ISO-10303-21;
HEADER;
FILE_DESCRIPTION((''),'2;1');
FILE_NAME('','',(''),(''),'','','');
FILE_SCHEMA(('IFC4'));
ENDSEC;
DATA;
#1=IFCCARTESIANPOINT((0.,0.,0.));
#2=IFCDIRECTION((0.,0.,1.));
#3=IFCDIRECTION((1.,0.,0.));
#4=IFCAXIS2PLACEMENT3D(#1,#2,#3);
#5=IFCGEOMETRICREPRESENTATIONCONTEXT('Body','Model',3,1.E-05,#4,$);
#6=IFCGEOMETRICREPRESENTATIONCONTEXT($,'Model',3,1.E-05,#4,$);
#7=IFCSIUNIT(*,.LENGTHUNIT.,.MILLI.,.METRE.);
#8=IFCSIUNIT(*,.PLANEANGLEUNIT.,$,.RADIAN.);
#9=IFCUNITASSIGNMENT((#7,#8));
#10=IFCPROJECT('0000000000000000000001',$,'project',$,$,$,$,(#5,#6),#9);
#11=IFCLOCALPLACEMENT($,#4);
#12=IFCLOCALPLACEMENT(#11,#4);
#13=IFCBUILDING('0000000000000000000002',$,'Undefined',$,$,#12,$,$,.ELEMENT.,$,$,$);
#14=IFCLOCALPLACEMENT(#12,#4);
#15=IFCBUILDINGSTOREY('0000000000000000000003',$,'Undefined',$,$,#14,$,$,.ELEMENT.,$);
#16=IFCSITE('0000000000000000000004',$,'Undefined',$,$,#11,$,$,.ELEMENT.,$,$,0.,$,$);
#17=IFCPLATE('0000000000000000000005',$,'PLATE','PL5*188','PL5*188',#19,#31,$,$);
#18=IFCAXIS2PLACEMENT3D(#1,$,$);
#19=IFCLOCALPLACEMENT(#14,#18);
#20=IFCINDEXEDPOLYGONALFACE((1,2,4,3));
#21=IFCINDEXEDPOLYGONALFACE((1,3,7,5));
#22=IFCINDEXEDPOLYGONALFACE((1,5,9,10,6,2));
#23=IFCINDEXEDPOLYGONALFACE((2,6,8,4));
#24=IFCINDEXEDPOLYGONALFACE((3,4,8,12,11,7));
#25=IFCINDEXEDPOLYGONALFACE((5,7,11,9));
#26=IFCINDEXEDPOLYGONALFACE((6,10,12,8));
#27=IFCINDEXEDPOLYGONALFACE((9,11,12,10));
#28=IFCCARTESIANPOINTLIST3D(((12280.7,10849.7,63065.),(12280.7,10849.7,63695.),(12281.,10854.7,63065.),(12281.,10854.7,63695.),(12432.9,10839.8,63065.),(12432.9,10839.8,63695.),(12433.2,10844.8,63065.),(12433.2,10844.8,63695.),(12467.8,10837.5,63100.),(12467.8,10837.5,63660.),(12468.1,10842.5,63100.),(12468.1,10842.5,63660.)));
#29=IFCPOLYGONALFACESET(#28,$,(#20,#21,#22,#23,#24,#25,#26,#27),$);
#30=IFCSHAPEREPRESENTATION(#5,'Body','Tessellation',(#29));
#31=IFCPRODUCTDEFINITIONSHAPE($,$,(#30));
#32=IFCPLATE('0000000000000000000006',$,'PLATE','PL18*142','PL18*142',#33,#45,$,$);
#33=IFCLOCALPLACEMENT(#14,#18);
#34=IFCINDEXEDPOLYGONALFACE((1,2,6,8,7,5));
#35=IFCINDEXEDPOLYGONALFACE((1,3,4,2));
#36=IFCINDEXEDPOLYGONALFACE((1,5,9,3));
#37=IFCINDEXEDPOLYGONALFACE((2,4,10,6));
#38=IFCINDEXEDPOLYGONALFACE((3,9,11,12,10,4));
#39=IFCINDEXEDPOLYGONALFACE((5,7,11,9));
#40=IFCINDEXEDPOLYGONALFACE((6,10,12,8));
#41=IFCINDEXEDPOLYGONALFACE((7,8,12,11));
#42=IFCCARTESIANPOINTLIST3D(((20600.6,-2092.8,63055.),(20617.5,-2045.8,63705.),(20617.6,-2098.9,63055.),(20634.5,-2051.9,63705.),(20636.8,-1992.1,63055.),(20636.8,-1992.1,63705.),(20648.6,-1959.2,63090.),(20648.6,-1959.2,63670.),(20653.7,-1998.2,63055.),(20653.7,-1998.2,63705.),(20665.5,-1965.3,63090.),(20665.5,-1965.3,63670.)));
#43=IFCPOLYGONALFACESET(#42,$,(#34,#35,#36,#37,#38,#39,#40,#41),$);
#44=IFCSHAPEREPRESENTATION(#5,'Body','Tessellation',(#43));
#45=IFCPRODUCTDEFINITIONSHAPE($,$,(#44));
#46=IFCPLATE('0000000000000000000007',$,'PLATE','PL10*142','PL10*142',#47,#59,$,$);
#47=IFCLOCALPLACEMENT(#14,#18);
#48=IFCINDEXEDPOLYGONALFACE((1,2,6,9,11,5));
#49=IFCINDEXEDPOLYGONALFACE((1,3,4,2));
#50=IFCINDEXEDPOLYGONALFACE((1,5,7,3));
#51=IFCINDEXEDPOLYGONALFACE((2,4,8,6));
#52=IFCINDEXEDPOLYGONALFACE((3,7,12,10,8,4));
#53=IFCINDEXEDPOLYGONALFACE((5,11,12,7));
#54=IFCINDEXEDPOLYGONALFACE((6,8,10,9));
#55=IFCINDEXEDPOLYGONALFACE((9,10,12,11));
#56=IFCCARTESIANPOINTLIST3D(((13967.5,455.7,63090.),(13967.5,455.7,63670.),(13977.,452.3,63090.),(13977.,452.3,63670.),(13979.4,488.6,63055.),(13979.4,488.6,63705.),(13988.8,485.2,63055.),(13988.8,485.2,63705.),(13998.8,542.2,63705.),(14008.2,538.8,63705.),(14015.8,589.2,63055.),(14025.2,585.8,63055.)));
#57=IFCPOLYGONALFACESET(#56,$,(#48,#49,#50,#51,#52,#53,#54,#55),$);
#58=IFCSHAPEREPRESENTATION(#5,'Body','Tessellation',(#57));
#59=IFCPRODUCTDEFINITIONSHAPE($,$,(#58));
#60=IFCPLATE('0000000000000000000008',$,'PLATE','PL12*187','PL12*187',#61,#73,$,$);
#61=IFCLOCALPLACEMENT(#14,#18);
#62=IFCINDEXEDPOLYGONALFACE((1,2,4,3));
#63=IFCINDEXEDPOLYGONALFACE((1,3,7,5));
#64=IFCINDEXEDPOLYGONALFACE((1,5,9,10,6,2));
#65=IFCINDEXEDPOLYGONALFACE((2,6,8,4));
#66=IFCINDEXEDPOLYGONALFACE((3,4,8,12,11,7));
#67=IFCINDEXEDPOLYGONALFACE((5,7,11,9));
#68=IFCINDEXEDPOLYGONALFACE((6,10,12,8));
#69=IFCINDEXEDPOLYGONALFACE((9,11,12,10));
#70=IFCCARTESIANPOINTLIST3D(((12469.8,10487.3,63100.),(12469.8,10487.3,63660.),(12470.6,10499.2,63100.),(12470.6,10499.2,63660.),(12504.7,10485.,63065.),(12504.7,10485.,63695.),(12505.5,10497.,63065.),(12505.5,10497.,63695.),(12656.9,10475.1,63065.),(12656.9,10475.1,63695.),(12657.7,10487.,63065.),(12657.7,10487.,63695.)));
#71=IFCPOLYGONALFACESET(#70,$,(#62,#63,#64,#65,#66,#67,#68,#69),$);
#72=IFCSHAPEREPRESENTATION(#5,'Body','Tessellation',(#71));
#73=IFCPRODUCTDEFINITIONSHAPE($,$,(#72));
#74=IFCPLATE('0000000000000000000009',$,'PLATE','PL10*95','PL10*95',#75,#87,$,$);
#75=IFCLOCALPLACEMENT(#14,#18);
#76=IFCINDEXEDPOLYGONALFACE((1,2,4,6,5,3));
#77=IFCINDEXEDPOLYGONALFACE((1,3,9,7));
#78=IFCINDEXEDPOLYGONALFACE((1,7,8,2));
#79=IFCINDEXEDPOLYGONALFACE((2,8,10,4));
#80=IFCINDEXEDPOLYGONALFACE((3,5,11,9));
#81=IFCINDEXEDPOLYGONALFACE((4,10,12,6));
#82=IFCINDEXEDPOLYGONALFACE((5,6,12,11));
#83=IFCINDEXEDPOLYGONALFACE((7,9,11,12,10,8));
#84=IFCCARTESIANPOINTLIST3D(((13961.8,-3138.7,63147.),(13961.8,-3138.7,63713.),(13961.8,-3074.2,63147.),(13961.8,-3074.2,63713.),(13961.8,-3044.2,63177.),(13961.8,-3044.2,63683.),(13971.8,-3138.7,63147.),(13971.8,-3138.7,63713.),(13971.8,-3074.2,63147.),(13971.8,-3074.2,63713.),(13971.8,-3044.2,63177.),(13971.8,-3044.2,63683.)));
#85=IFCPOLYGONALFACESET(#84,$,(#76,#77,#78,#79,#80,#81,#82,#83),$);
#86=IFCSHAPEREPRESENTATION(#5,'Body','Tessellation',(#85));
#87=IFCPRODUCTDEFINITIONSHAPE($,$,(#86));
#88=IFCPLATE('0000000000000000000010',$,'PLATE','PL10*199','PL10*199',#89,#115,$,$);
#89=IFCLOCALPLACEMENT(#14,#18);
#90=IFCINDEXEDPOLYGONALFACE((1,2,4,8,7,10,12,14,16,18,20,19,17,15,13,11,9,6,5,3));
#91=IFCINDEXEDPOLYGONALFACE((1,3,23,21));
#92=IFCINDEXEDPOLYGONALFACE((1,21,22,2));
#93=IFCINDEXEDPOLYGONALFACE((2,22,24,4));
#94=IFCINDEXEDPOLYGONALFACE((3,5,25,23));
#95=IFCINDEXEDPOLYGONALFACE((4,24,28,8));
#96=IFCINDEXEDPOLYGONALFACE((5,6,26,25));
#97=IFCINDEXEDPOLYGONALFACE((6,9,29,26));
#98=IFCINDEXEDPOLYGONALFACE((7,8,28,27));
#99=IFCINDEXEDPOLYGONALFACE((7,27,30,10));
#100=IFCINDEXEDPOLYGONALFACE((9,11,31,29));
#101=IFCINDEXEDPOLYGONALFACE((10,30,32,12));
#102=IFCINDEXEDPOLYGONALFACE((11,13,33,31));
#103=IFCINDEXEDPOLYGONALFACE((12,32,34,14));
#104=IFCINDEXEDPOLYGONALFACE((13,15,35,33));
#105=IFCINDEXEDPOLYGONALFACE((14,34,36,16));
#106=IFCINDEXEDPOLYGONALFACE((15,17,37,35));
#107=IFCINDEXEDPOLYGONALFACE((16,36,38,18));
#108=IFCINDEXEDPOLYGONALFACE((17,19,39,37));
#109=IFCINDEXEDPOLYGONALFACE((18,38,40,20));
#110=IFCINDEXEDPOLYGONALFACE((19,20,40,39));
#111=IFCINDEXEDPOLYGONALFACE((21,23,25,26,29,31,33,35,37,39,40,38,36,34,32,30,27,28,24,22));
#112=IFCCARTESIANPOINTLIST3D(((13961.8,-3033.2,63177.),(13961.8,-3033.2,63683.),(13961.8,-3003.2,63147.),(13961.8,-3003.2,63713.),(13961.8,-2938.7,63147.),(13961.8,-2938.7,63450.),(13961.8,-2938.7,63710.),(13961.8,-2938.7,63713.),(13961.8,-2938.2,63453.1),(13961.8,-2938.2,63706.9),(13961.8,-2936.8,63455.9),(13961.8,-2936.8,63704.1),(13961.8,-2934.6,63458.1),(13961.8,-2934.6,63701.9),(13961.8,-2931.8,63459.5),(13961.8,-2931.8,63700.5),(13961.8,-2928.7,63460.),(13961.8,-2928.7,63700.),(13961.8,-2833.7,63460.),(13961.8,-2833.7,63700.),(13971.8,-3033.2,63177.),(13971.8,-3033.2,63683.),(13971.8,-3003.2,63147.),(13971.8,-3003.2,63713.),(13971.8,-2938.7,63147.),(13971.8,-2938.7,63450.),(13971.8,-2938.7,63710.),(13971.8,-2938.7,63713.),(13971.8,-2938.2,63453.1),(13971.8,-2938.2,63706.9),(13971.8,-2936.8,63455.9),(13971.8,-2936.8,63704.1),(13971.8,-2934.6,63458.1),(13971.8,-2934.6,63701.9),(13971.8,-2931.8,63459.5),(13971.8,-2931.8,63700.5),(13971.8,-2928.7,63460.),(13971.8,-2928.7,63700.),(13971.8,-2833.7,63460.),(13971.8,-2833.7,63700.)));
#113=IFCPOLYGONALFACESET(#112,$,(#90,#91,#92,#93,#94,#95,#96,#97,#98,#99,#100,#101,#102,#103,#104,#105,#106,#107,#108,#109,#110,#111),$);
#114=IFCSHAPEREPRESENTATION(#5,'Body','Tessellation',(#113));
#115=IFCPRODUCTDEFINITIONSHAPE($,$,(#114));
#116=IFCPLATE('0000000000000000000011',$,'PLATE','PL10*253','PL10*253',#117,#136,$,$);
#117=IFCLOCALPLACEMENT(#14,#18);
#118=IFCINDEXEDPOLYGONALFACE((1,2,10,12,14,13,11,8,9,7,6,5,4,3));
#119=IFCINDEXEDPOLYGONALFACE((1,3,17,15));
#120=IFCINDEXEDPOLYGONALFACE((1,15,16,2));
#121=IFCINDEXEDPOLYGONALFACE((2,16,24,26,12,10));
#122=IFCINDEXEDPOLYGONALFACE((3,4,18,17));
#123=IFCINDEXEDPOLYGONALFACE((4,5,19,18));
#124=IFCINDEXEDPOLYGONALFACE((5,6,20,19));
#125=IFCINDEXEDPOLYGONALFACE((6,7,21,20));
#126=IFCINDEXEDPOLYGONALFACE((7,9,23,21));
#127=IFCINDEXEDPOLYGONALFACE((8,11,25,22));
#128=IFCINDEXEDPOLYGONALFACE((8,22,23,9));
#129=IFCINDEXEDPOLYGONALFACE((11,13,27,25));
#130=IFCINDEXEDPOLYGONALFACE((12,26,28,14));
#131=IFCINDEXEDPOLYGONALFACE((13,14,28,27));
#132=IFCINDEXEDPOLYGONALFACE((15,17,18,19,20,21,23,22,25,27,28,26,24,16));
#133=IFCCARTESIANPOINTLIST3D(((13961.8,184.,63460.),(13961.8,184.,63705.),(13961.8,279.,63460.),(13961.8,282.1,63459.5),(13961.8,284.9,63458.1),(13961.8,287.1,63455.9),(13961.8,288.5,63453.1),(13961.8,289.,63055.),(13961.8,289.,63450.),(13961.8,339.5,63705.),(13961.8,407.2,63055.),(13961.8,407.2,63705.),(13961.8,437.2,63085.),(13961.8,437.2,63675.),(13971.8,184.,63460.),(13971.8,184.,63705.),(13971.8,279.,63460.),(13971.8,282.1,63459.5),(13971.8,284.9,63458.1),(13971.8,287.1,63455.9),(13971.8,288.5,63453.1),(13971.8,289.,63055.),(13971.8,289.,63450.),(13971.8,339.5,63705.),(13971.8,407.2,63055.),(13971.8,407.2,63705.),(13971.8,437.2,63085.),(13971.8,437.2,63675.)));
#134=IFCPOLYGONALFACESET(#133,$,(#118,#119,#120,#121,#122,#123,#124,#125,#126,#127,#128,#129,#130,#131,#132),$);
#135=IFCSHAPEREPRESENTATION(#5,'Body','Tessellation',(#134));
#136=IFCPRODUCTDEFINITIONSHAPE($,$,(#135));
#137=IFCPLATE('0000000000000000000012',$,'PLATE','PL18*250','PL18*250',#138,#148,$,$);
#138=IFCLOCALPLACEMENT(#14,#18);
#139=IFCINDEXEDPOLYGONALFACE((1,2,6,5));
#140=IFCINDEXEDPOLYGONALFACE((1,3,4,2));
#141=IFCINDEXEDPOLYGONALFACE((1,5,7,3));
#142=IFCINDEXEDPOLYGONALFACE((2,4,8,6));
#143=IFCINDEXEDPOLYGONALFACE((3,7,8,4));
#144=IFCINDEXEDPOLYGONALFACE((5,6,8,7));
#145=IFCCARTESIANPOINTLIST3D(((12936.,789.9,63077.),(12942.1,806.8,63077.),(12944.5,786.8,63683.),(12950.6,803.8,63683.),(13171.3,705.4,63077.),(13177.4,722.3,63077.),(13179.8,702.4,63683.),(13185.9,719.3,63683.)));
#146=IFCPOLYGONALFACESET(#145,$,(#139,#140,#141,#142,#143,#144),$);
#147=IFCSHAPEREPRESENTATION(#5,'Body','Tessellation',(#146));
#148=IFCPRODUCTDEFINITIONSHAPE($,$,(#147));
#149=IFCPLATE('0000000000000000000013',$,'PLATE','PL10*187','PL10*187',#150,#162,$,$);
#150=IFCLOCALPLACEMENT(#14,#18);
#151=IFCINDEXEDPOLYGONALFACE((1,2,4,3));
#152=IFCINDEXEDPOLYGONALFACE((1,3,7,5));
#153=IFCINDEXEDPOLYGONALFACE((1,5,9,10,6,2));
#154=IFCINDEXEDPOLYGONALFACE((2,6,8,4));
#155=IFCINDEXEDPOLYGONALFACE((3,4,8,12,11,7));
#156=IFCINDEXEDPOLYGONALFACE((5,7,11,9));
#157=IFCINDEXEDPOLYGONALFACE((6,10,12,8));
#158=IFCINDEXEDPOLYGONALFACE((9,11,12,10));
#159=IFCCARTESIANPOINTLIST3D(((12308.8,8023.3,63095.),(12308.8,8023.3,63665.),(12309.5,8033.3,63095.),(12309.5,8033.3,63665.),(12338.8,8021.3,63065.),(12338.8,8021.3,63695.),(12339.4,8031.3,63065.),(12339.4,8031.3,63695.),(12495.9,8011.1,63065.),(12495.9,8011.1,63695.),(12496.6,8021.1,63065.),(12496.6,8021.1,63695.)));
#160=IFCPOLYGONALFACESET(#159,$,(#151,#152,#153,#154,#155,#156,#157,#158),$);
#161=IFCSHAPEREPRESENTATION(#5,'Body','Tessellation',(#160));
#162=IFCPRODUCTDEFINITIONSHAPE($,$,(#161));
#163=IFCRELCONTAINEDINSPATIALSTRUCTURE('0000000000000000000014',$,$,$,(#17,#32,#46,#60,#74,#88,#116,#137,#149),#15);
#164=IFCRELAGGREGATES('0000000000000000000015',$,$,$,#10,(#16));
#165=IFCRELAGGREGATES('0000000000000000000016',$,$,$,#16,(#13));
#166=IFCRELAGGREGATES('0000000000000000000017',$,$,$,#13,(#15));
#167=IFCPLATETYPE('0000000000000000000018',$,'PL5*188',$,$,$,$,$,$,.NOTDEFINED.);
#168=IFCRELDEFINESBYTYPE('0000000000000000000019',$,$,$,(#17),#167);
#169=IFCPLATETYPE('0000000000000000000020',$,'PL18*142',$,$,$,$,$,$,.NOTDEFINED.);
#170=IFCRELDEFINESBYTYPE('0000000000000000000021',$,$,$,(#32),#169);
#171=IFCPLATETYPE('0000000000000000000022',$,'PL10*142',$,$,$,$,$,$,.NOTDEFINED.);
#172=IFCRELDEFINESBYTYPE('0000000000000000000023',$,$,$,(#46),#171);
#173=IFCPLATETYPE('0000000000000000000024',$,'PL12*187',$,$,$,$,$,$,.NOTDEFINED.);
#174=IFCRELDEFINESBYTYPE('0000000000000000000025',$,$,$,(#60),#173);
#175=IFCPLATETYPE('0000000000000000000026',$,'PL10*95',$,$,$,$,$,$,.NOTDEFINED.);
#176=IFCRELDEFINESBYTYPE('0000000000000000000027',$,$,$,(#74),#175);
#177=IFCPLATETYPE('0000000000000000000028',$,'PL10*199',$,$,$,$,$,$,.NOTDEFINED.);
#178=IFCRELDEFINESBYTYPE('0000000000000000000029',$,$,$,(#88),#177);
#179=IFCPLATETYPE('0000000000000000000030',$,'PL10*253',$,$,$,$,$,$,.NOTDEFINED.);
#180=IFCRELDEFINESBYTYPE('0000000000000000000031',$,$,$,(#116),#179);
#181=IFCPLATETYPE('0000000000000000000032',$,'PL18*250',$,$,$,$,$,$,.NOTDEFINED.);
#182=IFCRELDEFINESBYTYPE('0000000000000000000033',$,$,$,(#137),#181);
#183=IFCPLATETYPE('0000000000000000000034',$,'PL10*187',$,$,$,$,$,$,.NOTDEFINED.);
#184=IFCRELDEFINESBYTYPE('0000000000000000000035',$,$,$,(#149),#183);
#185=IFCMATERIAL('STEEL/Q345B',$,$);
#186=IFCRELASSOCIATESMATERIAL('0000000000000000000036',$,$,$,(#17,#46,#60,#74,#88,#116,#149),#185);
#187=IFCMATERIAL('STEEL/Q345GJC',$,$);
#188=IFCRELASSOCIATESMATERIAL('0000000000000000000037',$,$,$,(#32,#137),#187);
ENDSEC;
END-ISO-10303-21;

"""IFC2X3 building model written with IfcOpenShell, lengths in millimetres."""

from ifc_helpers import new_model, si_unit, frame, origin_with_axes, place, context, project, spatial, polyline, outline, extrude, material, type_object, element, save


model = new_model("IFC2X3")

# Units and contexts
model_context_1 = context("Model", 3, precision=1e-05, world=origin_with_axes(), identifier="Body")
model_context_2 = context("Model", 3, precision=1e-05, world=origin_with_axes())
ifc_project = project(units=[si_unit("LENGTHUNIT", "METRE", prefix="MILLI"), si_unit("PLANEANGLEUNIT", "RADIAN")], contexts=[model_context_1, model_context_2])

# Site, building, storey
site_placement = place(None, origin_with_axes())
site = spatial("IfcSite", under=ifc_project, at=site_placement, Name="Undefined", CompositionType="ELEMENT", RefElevation=0.0)
building_placement = place(site_placement, origin_with_axes())
building = spatial("IfcBuilding", under=site, at=building_placement, Name="Undefined", CompositionType="ELEMENT")
storey_placement = place(building_placement, origin_with_axes())
storey = spatial("IfcBuildingStorey", under=building, at=storey_placement, Name="Undefined", CompositionType="ELEMENT")

# Shared definitions
ifc_material_1 = material(Name="STEEL/Q345B")
ifc_material_2 = material(Name="STEEL/Q345GJC")

# Plates
plate_type_1 = type_object("IfcPlateType", Name="PL5*188", PredefinedType="NOTDEFINED")
plate_1_placement = place(storey_placement, frame((12280.8, 10852.2, 63695.0), z_axis=(0.065171, 0.997874, 0.0), x_axis=(0.997874, -0.065171, 0.0)))
element("IfcPlate", 1, at=plate_1_placement, inside=storey, type_object=plate_type_1, material=ifc_material_1, Name="PLATE", Description="PL5*188", ObjectType="PL5*188", context=model_context_1, shape_type="SweptSolid", body=[
    extrude(outline(polyline([(0.0, 0.0), (152.5, 0.0), (187.5, 35.0), (187.5, 595.0), (152.5, 630.0), (0.0, 630.0), (0.0, 0.0)])), frame((0.0, 0.0, -2.5), z_axis=(0.0, 0.0, 1.0), x_axis=(1.0, 0.0, 0.0)), (0.0, 0.0, 1.0), 5.0),
])
plate_type_2 = type_object("IfcPlateType", Name="PL18*142", PredefinedType="NOTDEFINED")
plate_2_placement = place(storey_placement, frame((20657.1, -1962.2, 63705.0), z_axis=(0.941212, -0.337816, 0.0), x_axis=(-0.337816, -0.941212, 0.0)))
element("IfcPlate", 2, at=plate_2_placement, inside=storey, type_object=plate_type_2, material=ifc_material_2, Name="PLATE", Description="PL18*142", ObjectType="PL18*142", context=model_context_1, shape_type="SweptSolid", body=[
    extrude(outline(polyline([(0.0, 35.0), (35.0, 0.0), (92.0, 0.0), (142.0, 650.0), (35.0, 650.0), (0.0, 615.0), (0.0, 35.0)])), frame((0.0, 0.0, -9.0), z_axis=(0.0, 0.0, 1.0), x_axis=(1.0, 0.0, 0.0)), (0.0, 0.0, 1.0), 18.0),
])
plate_type_3 = type_object("IfcPlateType", Name="PL10*142", PredefinedType="NOTDEFINED")
plate_3_placement = place(storey_placement, frame((13972.2, 454.0, 63705.0), z_axis=(-0.940467, 0.339884, 0.0), x_axis=(0.339884, 0.940467, 0.0)))
element("IfcPlate", 3, at=plate_3_placement, inside=storey, type_object=plate_type_3, material=ifc_material_1, Name="PLATE", Description="PL10*142", ObjectType="PL10*142", context=model_context_1, shape_type="SweptSolid", body=[
    extrude(outline(polyline([(0.0, 35.0), (35.0, 0.0), (92.0, 0.0), (142.0, 650.0), (35.0, 650.0), (0.0, 615.0), (0.0, 35.0)])), frame((0.0, 0.0, -5.0), z_axis=(0.0, 0.0, 1.0), x_axis=(1.0, 0.0, 0.0)), (0.0, 0.0, 1.0), 10.0),
])
plate_type_4 = type_object("IfcPlateType", Name="PL12*187", PredefinedType="NOTDEFINED")
plate_4_placement = place(storey_placement, frame((12470.2, 10493.3, 63065.0), z_axis=(-0.065183, -0.997873, 0.0), x_axis=(0.997873, -0.065183, 0.0)))
element("IfcPlate", 4, at=plate_4_placement, inside=storey, type_object=plate_type_4, material=ifc_material_1, Name="PLATE", Description="PL12*187", ObjectType="PL12*187", context=model_context_1, shape_type="SweptSolid", body=[
    extrude(outline(polyline([(0.0, 35.0), (35.0, 0.0), (187.5, 0.0), (187.5, 630.0), (35.0, 630.0), (0.0, 595.0), (0.0, 35.0)])), frame((0.0, 0.0, -6.0), z_axis=(0.0, 0.0, 1.0), x_axis=(1.0, 0.0, 0.0)), (0.0, 0.0, 1.0), 12.0),
])
plate_type_5 = type_object("IfcPlateType", Name="PL10*95", PredefinedType="NOTDEFINED")
plate_5_placement = place(storey_placement, frame((13966.8, -3044.2, 63147.0), z_axis=(-1.0, 0.0, 0.0), x_axis=(0.0, -1.0, 0.0)))
element("IfcPlate", 5, at=plate_5_placement, inside=storey, type_object=plate_type_5, material=ifc_material_1, Name="PLATE", Description="PL10*95", ObjectType="PL10*95", context=model_context_1, shape_type="SweptSolid", body=[
    extrude(outline(polyline([(0.0, 30.0), (30.0, 0.0), (94.5, 0.0), (94.5, 566.0), (30.0, 566.0), (0.0, 536.0), (0.0, 30.0)])), frame((0.0, 0.0, -5.0), z_axis=(0.0, 0.0, 1.0), x_axis=(1.0, 0.0, 0.0)), (0.0, 0.0, 1.0), 10.0),
])
plate_type_6 = type_object("IfcPlateType", Name="PL10*199", PredefinedType="NOTDEFINED")
plate_6_placement = place(storey_placement, frame((13966.8, -3033.2, 63177.0), z_axis=(1.0, 0.0, 0.0), x_axis=(0.0, 0.707107, -0.707107)))
element("IfcPlate", 6, at=plate_6_placement, inside=storey, type_object=plate_type_6, material=ifc_material_1, Name="PLATE", Description="PL10*199", ObjectType="PL10*199", context=model_context_1, shape_type="SweptSolid", body=[
    extrude(outline(polyline([(0.0, 0.0), (42.4, 0.0), (88.0, 45.6), (-126.2, 259.9), (-128.1, 262.4), (-129.0, 265.4), (-129.0, 268.5), (-128.1, 271.5), (-126.2, 274.0), (-59.0, 341.2), (-228.7, 510.9), (-295.9, 443.7), (-298.5, 441.9), (-301.4, 440.9), (-304.6, 440.9), (-307.5, 441.9), (-310.1, 443.7), (-312.2, 445.8), (-357.8, 400.2), (-357.8, 357.8), (0.0, 0.0)])), frame((0.0, 0.0, -5.0), z_axis=(0.0, 0.0, 1.0), x_axis=(1.0, 0.0, 0.0)), (0.0, 0.0, 1.0), 10.0),
])
plate_type_7 = type_object("IfcPlateType", Name="PL10*253", PredefinedType="NOTDEFINED")
plate_7_placement = place(storey_placement, frame((13966.8, 437.2, 63085.0), z_axis=(-1.0, 0.0, 0.0), x_axis=(0.0, -0.707107, -0.707107)))
element("IfcPlate", 7, at=plate_7_placement, inside=storey, type_object=plate_type_7, material=ifc_material_1, Name="PLATE", Description="PL10*253", ObjectType="PL10*253", context=model_context_1, shape_type="SweptSolid", body=[
    extrude(outline(polyline([(0.0, 0.0), (42.4, 0.0), (126.0, 83.6), (-153.3, 362.9), (-155.1, 365.4), (-156.1, 368.4), (-156.1, 371.5), (-155.1, 374.5), (-153.3, 377.0), (-86.1, 444.2), (-259.4, 617.5), (-369.3, 507.5), (-417.2, 459.6), (-417.2, 417.2), (0.0, 0.0)])), frame((0.0, 0.0, -5.0), z_axis=(0.0, 0.0, 1.0), x_axis=(1.0, 0.0, 0.0)), (0.0, 0.0, 1.0), 10.0),
])
plate_type_8 = type_object("IfcPlateType", Name="PL18*250", PredefinedType="NOTDEFINED")
plate_8_placement = place(storey_placement, frame((13182.9, 710.8, 63683.0), z_axis=(-0.337816, -0.941212, 0.0), x_axis=(-0.941212, 0.337816, 0.0)))
element("IfcPlate", 8, at=plate_8_placement, inside=storey, type_object=plate_type_8, material=ifc_material_2, Name="PLATE", Description="PL18*250", ObjectType="PL18*250", context=model_context_1, shape_type="SweptSolid", body=[
    extrude(outline(polyline([(0.0, 0.0), (250.0, 0.0), (259.0, 606.0), (9.0, 606.0), (0.0, 0.0)])), frame((0.0, 0.0, -9.0), z_axis=(0.0, 0.0, 1.0), x_axis=(1.0, 0.0, 0.0)), (0.0, 0.0, 1.0), 18.0),
])
plate_type_9 = type_object("IfcPlateType", Name="PL10*187", PredefinedType="NOTDEFINED")
plate_9_placement = place(storey_placement, frame((12309.2, 8028.3, 63065.0), z_axis=(-0.065183, -0.997873, 0.0), x_axis=(0.997873, -0.065183, 0.0)))
element("IfcPlate", 9, at=plate_9_placement, inside=storey, type_object=plate_type_9, material=ifc_material_1, Name="PLATE", Description="PL10*187", ObjectType="PL10*187", context=model_context_1, shape_type="SweptSolid", body=[
    extrude(outline(polyline([(0.0, 30.0), (30.0, 0.0), (187.5, 0.0), (187.5, 630.0), (30.0, 630.0), (0.0, 600.0), (0.0, 30.0)])), frame((0.0, 0.0, -5.0), z_axis=(0.0, 0.0, 1.0), x_axis=(1.0, 0.0, 0.0)), (0.0, 0.0, 1.0), 10.0),
])

save(model, "model.ifc")
